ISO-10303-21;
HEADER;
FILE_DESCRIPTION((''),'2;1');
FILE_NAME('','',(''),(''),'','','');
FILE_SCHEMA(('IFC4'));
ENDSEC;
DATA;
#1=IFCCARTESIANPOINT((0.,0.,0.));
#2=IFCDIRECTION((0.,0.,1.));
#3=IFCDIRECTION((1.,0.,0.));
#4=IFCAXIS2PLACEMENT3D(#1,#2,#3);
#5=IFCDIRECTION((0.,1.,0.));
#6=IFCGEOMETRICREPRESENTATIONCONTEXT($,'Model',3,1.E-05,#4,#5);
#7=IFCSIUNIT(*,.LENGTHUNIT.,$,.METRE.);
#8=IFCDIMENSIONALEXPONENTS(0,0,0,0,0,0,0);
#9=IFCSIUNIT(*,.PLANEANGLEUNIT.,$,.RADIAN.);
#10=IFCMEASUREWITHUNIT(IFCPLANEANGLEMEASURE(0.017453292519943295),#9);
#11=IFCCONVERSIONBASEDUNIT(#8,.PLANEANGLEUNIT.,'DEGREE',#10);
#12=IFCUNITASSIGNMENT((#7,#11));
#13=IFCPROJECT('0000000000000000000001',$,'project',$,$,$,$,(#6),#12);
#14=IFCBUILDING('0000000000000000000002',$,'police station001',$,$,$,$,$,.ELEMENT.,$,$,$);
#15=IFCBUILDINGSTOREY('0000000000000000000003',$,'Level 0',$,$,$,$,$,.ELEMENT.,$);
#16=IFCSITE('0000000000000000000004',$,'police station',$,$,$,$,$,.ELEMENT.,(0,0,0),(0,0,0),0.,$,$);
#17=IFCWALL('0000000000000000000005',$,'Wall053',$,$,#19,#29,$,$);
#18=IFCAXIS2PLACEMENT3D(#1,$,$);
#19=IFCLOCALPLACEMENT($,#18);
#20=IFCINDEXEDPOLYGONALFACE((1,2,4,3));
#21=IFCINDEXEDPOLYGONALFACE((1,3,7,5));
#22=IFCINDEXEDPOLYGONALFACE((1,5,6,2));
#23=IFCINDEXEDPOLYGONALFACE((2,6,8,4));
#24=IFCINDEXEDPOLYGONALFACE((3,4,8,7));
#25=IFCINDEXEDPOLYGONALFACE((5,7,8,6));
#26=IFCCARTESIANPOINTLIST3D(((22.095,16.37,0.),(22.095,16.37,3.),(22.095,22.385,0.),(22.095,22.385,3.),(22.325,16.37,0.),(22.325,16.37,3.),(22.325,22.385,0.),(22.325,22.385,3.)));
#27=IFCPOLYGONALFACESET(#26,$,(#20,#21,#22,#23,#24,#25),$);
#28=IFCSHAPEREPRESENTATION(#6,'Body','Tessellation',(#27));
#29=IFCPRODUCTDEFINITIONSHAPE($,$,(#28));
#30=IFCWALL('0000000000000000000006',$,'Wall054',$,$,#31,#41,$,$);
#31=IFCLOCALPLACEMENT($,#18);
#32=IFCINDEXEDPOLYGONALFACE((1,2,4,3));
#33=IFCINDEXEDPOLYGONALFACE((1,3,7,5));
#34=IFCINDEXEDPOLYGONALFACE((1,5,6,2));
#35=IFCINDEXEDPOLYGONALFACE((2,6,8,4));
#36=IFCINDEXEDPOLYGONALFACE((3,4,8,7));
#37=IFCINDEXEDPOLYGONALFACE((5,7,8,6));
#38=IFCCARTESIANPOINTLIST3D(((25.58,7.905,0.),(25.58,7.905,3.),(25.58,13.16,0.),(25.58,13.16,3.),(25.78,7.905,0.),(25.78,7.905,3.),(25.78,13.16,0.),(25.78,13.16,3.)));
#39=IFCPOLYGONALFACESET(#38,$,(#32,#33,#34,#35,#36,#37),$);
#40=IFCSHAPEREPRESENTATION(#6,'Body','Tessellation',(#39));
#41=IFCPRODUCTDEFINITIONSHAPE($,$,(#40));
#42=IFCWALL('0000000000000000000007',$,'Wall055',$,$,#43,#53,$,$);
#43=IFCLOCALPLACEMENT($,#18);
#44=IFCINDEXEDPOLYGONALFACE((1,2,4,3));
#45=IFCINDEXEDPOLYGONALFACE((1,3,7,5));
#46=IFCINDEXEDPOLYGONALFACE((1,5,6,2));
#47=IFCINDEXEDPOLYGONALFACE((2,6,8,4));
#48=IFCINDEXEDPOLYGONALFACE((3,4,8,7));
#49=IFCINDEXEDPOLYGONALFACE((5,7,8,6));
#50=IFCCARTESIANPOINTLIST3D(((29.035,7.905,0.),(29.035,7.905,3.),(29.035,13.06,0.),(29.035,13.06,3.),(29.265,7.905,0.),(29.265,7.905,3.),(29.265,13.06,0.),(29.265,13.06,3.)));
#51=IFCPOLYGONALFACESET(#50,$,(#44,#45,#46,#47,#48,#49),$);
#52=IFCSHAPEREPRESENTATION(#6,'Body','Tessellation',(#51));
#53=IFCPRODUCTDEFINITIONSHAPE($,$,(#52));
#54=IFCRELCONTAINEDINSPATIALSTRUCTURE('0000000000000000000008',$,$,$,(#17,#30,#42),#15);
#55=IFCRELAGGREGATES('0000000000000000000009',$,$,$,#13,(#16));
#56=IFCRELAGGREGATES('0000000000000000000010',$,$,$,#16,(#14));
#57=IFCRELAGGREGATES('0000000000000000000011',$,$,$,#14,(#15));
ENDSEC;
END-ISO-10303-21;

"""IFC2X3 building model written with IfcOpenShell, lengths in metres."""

from ifc_helpers import new_model, entity, si_unit, converted_unit, direction, frame, frame_2d, origin_with_axes, place, context, project, spatial, rectangle, extrude, element, save


model = new_model("IFC2X3")

# Units and contexts
model_context = context("Model", 3, precision=1e-05, world=origin_with_axes(), true_north=direction((0.0, 1.0, 0.0)))
ifc_project = project(units=[si_unit("LENGTHUNIT", "METRE"), converted_unit("PLANEANGLEUNIT", "DEGREE", entity("IfcPlaneAngleMeasure", 0.017453292519943295), si_unit("PLANEANGLEUNIT", "RADIAN"), dimensions=[0, 0, 0, 0, 0, 0, 0])], contexts=[model_context])

# Site, building, storey
site = spatial("IfcSite", under=ifc_project, Name="police station", CompositionType="ELEMENT", RefLatitude=(0, 0, 0), RefLongitude=(0, 0, 0), RefElevation=0.0)
building = spatial("IfcBuilding", under=site, Name="police station001", CompositionType="ELEMENT")
storey = spatial("IfcBuildingStorey", under=building, Name="Level 0", CompositionType="ELEMENT")

# Shared definitions
placement = place(None, origin_with_axes())

# Walls
element("IfcWall", 1, at=placement, inside=storey, Name="Wall053", context=model_context, shape_type="SweptSolid", body=[
    extrude(rectangle(XDim=6.015, YDim=0.23, at=frame_2d((0.0, 0.0), x_axis=(0.0, -1.0, 0.0))), frame((22.21, 19.3775, 0.0), z_axis=(0.0, 0.0, 1.0), x_axis=(1.0, 0.0, 0.0)), (0.0, 0.0, 1.0), 3.0),
])
element("IfcWall", 2, at=placement, inside=storey, Name="Wall054", context=model_context, shape_type="SweptSolid", body=[
    extrude(rectangle(XDim=5.255, YDim=0.2, at=frame_2d((0.0, 0.0), x_axis=(0.0, -1.0, 0.0))), frame((25.68, 10.5325, 0.0), z_axis=(0.0, 0.0, 1.0), x_axis=(1.0, 0.0, 0.0)), (0.0, 0.0, 1.0), 3.0),
])
element("IfcWall", 3, at=placement, inside=storey, Name="Wall055", context=model_context, shape_type="SweptSolid", body=[
    extrude(rectangle(XDim=5.155, YDim=0.23, at=frame_2d((0.0, 0.0), x_axis=(0.0, -1.0, 0.0))), frame((29.15, 10.4825, 0.0), z_axis=(0.0, 0.0, 1.0), x_axis=(1.0, 0.0, 0.0)), (0.0, 0.0, 1.0), 3.0),
])

save(model, "model.ifc")
